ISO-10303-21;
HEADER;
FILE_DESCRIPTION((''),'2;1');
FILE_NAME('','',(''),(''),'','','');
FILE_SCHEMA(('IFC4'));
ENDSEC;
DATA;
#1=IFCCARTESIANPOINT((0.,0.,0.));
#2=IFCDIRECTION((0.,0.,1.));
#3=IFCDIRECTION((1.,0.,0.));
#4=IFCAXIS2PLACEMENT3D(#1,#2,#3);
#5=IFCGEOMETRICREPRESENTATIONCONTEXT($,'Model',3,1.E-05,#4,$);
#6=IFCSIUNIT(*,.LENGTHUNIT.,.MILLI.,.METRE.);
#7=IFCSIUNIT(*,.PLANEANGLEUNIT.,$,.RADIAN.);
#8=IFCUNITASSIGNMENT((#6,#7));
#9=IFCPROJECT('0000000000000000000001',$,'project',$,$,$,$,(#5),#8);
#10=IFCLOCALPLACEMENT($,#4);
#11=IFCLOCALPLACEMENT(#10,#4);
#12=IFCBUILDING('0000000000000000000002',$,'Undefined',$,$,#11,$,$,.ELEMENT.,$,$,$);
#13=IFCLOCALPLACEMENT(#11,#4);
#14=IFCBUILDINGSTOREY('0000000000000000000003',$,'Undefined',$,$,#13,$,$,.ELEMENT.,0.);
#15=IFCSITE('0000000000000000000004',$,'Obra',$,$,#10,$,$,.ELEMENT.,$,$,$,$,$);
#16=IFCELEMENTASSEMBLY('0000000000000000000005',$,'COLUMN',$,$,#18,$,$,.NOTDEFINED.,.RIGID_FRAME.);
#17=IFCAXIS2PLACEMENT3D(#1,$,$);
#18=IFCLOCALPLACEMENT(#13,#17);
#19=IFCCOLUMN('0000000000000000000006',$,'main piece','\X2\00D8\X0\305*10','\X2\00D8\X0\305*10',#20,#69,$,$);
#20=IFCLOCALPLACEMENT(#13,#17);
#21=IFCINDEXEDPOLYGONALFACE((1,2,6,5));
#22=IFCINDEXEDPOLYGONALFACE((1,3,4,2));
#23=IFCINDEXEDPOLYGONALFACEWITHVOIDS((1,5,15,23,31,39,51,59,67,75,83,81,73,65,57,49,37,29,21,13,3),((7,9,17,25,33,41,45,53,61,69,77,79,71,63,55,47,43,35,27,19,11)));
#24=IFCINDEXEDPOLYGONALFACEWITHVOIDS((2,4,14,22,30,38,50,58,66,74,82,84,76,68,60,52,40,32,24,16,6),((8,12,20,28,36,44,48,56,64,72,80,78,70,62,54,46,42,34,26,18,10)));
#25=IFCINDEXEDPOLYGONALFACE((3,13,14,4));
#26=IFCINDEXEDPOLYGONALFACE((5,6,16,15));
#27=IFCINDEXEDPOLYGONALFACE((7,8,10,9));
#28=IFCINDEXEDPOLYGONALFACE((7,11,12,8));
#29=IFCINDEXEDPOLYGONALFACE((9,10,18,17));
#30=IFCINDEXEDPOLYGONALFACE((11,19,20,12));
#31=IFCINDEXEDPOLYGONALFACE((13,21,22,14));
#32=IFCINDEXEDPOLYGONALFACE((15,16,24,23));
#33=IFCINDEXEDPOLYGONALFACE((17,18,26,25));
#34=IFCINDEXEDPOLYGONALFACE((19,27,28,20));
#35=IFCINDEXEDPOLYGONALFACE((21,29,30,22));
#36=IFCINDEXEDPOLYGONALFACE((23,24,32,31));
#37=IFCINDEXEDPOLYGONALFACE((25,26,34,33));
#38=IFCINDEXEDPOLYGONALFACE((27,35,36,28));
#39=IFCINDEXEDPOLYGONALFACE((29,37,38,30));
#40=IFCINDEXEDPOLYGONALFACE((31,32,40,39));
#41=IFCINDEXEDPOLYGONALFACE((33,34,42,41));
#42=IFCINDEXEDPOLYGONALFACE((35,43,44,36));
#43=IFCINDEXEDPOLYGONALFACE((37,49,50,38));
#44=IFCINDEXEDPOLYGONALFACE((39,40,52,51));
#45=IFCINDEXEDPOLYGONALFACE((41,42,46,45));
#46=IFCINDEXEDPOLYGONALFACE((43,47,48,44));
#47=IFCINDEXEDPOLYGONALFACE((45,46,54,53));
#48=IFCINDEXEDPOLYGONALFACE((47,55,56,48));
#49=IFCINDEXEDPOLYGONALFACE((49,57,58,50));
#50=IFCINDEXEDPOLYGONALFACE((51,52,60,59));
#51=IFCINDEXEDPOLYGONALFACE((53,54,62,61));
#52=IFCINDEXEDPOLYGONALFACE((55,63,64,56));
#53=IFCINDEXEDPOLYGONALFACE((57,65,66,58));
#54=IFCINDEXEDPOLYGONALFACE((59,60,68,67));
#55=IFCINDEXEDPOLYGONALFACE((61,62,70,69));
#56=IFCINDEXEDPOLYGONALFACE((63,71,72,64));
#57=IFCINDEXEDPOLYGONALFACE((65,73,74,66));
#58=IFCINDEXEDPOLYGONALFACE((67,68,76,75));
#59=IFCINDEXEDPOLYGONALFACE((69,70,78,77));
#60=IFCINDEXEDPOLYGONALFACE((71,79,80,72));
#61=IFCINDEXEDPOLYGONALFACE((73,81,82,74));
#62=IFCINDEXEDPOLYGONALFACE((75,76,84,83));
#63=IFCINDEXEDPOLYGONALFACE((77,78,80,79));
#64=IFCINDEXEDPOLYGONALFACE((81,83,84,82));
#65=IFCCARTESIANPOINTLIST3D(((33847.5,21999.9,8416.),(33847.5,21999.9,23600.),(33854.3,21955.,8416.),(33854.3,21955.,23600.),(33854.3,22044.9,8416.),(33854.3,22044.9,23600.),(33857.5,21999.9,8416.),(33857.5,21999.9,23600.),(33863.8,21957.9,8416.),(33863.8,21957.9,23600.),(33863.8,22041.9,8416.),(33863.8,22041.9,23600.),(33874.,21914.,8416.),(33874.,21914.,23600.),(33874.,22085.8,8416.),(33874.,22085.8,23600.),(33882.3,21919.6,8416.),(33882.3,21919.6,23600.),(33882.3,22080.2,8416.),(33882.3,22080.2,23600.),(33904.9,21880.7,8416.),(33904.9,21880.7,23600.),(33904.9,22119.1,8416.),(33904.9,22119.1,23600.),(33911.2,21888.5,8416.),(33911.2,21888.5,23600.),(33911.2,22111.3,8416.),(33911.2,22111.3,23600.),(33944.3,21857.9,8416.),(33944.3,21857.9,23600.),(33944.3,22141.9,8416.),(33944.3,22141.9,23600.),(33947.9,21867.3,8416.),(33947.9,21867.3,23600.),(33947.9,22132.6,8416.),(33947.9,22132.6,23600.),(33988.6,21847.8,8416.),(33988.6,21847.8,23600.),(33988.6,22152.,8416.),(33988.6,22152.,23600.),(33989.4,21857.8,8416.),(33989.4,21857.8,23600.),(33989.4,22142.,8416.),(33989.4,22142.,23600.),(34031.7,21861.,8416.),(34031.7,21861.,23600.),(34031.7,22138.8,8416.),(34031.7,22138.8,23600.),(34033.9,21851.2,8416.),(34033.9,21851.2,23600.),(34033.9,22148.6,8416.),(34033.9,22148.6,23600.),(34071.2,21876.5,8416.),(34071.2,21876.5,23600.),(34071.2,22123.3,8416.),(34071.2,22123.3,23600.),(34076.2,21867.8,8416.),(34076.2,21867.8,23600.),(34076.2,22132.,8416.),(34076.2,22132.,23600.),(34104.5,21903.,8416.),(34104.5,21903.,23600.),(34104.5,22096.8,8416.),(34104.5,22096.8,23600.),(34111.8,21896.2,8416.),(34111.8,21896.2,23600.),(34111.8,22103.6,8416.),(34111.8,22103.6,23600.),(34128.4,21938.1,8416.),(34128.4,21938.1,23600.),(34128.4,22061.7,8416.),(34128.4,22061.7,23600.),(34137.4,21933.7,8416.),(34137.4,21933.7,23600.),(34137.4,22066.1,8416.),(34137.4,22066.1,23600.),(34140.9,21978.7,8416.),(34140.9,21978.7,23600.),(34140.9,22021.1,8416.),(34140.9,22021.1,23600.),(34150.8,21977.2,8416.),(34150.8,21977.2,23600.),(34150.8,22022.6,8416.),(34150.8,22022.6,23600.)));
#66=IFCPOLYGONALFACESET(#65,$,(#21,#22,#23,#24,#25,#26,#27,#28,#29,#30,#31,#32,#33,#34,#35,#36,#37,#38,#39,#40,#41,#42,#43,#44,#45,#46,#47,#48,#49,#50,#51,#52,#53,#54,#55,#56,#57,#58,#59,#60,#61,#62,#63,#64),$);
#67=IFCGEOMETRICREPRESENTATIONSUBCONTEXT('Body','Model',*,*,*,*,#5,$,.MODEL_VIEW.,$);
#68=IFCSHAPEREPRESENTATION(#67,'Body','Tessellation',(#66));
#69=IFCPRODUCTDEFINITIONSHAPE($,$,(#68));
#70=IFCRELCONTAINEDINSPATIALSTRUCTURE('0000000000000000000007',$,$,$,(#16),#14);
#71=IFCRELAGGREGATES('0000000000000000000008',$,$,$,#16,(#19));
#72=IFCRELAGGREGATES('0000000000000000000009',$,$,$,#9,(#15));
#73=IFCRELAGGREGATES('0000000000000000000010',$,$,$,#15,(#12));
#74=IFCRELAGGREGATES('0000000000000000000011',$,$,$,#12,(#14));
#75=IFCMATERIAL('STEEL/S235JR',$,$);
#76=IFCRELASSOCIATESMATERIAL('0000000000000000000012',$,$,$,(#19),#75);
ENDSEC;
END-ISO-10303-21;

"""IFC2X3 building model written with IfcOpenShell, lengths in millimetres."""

from ifc_helpers import new_model, si_unit, frame, origin_with_axes, origin_2d_with_axis, place, context, subcontext, project, spatial, hollow_circle, extrude, clip, halfspace, material, element, aggregate, save


model = new_model("IFC2X3")

# Units and contexts
model_context = context("Model", 3, precision=1e-05, world=origin_with_axes())
body_context = subcontext(model_context, "Body", "Model", "MODEL_VIEW")
ifc_project = project(units=[si_unit("LENGTHUNIT", "METRE", prefix="MILLI"), si_unit("PLANEANGLEUNIT", "RADIAN")], contexts=[model_context])

# Site, building, storey
site_placement = place(None, origin_with_axes())
site = spatial("IfcSite", under=ifc_project, at=site_placement, Name="Obra", CompositionType="ELEMENT")
building_placement = place(site_placement, origin_with_axes())
building = spatial("IfcBuilding", under=site, at=building_placement, Name="Undefined", CompositionType="ELEMENT")
storey_placement = place(building_placement, origin_with_axes())
storey = spatial("IfcBuildingStorey", under=building, at=storey_placement, Name="Undefined", CompositionType="ELEMENT", Elevation=0.0)

# Element assembly, column
assembly_1_placement = place(storey_placement, origin_with_axes())
assembly_1 = element("IfcElementAssembly", 1, at=assembly_1_placement, inside=storey, Name="COLUMN", AssemblyPlace="NOTDEFINED", PredefinedType="RIGID_FRAME")
ifc_material_1 = material(Name="STEEL/S235JR")
column_placement = place(assembly_1_placement, frame((34000.0, 21999.9, 8400.0), z_axis=(0.0, 0.0, 1.0), x_axis=(0.0, 1.0, 0.0)))
column = element("IfcColumn", 2, at=column_placement, material=ifc_material_1, Name="main piece", Description="Ø305*10", ObjectType="Ø305*10", context=body_context, shape_type="Clipping", body=[
    clip(extrude(hollow_circle(Radius=152.5, WallThickness=10.0, at=origin_2d_with_axis()), frame((0.0, 0.0, 15200.0), z_axis=(0.0, 0.0, -1.0), x_axis=(0.0, 1.0, 0.0)), (0.0, 0.0, 1.0), 15184.0), halfspace(frame((-152.5, 0.0, 16.0), z_axis=(0.0, 0.0, 1.0), x_axis=(0.0, 1.0, 0.0)), True)),
])

aggregate(assembly_1, [column])

save(model, "model.ifc")
